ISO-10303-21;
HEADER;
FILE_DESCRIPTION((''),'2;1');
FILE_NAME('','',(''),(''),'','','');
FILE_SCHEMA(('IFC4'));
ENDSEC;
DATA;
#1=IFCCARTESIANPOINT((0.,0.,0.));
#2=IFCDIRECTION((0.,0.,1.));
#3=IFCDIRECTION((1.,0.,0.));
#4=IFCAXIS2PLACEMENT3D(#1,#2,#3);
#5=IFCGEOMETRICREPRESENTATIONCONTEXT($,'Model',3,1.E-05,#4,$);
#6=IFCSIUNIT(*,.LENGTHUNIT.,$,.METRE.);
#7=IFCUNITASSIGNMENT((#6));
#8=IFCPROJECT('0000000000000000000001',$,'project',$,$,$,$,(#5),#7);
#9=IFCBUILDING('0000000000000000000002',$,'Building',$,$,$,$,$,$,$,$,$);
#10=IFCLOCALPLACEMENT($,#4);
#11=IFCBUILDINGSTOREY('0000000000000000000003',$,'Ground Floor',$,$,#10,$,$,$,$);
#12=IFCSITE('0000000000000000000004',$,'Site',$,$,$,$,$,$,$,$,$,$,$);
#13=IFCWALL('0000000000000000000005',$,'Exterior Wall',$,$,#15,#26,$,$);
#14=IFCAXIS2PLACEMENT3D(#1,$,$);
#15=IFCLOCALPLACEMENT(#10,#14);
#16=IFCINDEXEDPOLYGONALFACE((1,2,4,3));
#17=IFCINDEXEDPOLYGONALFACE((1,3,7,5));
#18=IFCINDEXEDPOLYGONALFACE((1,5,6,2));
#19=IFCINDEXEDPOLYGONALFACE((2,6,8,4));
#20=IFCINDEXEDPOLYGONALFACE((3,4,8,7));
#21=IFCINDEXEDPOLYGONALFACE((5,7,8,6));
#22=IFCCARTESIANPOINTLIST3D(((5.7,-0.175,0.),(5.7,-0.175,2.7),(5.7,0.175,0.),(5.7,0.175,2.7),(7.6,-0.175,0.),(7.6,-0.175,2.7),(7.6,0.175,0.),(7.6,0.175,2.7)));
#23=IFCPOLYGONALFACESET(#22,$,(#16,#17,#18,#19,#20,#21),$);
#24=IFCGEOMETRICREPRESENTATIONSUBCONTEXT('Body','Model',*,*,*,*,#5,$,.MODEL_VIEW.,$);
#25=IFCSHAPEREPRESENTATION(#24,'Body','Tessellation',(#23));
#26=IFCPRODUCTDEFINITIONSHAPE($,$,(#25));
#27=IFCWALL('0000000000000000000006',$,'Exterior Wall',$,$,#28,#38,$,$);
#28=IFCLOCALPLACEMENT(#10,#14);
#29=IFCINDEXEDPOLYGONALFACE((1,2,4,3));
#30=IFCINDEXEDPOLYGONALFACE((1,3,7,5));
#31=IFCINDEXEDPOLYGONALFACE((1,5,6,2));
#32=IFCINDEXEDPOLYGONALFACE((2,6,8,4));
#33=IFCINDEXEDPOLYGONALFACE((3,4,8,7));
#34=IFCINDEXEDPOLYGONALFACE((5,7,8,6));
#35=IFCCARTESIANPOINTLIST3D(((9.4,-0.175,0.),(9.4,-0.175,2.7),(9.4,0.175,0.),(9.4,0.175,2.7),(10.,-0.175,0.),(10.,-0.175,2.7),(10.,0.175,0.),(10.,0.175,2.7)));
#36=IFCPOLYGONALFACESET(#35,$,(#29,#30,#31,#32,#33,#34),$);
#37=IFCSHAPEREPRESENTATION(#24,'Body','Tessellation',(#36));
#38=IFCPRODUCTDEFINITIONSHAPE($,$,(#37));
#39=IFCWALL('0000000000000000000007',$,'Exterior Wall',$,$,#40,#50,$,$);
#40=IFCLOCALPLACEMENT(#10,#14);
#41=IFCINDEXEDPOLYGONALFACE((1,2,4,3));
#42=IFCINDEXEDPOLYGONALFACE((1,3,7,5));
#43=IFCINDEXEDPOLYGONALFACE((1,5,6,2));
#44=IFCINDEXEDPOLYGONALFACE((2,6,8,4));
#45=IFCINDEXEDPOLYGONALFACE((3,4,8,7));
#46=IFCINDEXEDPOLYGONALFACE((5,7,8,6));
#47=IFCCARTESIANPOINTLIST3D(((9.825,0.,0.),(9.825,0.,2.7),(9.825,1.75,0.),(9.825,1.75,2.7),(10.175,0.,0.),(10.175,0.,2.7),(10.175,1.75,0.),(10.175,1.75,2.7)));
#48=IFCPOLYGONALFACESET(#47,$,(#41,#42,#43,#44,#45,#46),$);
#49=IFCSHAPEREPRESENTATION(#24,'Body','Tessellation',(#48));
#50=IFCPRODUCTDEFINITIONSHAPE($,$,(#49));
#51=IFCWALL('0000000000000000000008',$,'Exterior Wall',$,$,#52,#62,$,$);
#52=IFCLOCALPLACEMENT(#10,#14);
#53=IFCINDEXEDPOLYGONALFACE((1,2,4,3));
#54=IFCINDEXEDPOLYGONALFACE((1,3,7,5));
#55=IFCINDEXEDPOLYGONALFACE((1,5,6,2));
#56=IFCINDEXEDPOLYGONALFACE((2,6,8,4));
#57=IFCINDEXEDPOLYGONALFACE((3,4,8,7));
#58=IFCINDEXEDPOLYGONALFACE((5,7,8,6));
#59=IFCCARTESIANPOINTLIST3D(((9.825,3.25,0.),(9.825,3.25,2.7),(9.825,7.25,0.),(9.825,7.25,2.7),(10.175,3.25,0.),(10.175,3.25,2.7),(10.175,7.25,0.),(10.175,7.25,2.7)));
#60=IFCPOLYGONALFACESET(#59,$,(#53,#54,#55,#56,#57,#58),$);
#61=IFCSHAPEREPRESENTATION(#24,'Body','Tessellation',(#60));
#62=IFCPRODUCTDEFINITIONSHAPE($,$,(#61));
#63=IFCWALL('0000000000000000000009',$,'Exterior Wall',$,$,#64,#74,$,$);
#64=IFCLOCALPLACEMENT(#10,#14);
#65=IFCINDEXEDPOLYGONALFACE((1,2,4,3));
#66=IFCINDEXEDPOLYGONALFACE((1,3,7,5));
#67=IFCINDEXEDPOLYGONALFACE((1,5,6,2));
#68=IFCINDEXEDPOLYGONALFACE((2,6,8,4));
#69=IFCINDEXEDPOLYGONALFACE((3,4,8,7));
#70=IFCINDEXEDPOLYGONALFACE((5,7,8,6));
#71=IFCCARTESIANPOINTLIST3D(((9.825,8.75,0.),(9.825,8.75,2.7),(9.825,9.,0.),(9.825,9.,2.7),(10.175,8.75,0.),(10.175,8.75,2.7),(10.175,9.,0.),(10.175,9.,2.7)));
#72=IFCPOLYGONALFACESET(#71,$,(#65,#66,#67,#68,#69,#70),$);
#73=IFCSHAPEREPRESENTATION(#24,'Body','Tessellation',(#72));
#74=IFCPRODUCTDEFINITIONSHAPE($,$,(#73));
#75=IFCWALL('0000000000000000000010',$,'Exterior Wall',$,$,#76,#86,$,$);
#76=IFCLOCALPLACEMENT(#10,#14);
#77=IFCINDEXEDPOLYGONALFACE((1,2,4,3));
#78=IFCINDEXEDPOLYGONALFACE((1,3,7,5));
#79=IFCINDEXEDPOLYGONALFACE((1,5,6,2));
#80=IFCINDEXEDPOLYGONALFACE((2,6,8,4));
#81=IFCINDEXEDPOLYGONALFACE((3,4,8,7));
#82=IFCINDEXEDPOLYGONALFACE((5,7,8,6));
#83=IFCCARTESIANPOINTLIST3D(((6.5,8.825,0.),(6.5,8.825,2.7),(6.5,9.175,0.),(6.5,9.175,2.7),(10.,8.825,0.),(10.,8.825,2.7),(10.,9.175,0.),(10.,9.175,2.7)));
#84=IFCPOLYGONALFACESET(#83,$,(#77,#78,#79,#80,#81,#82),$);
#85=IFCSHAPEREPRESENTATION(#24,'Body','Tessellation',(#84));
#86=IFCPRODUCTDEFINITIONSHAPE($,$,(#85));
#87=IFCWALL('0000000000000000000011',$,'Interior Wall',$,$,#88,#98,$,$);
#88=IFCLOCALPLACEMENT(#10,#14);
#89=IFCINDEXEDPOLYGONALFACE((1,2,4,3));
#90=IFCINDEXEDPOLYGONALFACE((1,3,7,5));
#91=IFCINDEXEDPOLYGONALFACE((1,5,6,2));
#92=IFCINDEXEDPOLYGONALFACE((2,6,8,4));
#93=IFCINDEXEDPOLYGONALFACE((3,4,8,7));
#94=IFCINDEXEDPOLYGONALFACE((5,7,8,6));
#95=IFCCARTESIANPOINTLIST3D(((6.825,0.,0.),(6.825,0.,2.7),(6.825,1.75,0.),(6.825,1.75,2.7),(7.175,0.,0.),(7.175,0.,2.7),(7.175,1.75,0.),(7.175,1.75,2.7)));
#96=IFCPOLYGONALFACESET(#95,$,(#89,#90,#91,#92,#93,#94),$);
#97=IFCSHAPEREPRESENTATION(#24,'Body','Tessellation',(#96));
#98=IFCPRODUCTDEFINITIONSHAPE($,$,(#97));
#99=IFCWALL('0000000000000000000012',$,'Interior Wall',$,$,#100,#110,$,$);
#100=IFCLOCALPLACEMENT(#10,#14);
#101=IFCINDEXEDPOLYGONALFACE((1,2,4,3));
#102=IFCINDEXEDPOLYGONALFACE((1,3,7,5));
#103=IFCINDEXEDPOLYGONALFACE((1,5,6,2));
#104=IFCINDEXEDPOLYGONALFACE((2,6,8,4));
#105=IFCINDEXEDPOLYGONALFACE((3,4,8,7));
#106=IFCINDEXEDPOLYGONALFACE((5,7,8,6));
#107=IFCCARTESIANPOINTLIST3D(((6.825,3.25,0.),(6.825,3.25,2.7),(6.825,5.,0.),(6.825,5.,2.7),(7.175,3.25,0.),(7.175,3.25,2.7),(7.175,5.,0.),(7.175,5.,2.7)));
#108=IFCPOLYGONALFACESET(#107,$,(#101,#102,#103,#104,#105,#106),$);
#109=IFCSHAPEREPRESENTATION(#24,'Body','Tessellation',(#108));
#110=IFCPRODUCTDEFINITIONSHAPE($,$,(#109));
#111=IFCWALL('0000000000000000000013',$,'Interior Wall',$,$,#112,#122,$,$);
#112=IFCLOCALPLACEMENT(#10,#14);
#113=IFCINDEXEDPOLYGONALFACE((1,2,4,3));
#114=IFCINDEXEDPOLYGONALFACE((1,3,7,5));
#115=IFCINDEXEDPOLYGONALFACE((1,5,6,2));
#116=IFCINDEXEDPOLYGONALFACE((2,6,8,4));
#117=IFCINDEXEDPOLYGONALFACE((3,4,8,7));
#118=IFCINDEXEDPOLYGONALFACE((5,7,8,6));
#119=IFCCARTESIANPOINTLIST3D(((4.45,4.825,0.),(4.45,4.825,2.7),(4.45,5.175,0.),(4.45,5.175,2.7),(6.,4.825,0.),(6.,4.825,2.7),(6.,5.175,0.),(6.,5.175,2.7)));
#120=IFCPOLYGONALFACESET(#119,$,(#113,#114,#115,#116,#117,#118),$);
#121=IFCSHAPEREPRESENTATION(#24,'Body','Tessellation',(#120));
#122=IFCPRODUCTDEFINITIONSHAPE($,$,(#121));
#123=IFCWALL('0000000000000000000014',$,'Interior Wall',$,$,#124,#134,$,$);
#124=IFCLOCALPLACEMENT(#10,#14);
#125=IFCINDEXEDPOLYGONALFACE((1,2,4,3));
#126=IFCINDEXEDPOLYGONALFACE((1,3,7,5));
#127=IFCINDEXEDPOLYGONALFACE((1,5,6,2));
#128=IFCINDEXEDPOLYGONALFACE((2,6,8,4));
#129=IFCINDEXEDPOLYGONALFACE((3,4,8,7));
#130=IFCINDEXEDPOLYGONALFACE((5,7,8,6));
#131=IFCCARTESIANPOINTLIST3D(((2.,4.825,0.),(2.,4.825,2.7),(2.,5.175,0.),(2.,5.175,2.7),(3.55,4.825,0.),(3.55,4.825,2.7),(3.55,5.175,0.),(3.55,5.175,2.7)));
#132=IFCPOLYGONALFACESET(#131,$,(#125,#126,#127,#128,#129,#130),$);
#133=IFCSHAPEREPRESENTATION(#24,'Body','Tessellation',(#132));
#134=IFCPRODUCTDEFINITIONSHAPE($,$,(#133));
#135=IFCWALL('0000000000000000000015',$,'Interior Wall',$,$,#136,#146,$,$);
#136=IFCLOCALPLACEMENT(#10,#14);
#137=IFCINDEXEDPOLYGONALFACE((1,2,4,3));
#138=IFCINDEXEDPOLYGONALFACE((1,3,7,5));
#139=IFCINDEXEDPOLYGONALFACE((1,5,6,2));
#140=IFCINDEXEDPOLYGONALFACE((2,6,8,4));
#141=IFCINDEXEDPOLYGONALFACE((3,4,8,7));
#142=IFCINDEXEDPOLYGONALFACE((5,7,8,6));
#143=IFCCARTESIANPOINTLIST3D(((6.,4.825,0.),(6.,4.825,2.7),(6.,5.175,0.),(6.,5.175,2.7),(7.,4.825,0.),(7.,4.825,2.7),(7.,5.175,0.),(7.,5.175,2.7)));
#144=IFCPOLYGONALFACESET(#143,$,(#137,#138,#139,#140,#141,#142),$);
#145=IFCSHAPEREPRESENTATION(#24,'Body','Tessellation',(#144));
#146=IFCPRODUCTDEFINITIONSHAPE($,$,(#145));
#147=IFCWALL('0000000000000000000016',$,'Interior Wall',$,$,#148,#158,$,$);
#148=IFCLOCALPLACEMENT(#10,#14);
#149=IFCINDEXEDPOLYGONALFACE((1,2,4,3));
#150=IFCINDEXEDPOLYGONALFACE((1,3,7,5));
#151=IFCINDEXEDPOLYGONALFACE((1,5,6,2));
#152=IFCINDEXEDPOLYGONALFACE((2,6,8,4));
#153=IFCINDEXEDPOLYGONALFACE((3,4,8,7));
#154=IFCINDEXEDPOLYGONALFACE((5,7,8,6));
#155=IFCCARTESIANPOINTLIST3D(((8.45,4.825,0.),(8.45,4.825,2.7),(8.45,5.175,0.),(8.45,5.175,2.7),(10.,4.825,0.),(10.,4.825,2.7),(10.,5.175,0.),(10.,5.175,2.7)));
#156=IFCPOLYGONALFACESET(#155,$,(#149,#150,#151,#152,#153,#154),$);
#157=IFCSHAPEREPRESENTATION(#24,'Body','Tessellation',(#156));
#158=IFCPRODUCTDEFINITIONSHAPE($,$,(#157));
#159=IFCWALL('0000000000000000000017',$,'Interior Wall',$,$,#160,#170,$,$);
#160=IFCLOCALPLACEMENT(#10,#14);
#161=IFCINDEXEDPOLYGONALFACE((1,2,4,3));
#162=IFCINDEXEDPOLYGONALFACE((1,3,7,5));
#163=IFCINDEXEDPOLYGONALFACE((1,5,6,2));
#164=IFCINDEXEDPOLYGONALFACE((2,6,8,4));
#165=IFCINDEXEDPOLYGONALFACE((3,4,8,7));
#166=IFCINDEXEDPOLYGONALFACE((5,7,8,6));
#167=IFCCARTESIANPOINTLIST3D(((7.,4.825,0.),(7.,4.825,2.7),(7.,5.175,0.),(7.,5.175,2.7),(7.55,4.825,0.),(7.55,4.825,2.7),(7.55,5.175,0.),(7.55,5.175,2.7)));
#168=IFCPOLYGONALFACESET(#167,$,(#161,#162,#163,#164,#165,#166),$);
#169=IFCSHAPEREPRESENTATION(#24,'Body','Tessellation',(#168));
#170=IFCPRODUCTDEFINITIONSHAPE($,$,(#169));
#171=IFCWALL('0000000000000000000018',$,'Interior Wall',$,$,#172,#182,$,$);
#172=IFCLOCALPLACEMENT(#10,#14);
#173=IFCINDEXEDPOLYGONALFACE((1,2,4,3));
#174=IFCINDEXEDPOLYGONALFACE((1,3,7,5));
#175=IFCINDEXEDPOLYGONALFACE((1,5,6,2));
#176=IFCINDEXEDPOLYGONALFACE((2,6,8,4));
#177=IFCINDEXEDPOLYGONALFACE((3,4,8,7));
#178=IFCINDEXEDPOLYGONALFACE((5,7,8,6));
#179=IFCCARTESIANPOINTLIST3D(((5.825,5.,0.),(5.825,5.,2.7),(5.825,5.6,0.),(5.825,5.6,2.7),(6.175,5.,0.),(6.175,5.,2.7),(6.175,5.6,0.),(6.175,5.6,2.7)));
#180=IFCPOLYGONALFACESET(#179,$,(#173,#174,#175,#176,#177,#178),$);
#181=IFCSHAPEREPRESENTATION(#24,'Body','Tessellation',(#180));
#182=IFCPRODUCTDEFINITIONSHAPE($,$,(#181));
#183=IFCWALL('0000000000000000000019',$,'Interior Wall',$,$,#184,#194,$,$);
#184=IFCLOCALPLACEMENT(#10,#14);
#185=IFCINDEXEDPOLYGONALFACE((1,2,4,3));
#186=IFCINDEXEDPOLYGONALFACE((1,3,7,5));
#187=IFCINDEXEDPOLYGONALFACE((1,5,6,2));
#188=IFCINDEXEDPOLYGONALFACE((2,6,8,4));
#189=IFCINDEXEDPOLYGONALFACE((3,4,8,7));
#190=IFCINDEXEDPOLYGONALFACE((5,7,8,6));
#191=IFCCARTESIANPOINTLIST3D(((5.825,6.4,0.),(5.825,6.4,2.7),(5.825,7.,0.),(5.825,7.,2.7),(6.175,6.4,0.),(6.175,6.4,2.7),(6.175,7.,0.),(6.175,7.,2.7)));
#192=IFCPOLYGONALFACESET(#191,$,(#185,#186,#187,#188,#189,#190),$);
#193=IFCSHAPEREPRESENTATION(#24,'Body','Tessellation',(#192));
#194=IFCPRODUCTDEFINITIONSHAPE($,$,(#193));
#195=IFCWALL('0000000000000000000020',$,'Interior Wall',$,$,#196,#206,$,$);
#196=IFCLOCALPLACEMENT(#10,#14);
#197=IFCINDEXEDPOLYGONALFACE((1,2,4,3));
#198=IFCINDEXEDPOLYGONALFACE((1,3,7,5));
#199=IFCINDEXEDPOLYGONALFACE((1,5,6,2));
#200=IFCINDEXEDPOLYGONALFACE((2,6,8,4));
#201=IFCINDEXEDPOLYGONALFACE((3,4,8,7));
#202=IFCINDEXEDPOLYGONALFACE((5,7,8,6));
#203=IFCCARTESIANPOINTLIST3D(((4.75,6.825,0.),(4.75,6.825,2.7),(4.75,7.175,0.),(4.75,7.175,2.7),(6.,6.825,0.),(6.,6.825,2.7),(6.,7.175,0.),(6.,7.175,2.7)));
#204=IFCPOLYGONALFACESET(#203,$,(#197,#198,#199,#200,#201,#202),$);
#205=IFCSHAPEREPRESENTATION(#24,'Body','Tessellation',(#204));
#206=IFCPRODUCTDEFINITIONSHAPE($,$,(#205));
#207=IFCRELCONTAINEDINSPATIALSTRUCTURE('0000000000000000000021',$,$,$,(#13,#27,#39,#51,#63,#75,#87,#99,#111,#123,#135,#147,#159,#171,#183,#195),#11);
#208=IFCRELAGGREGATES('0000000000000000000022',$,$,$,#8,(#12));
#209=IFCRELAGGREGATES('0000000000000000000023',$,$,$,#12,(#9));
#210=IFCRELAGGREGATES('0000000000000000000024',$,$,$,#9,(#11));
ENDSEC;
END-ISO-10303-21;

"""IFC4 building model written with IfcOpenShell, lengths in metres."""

from ifc_helpers import new_model, si_unit, frame, origin_with_axes, place, context, subcontext, project, spatial, indexed_curve, outline, extrude, element, save


model = new_model("IFC4")

# Units and contexts
model_context = context("Model", 3, precision=1e-05, world=origin_with_axes())
body_context = subcontext(model_context, "Body", "Model", "MODEL_VIEW")
ifc_project = project(units=[si_unit("LENGTHUNIT", "METRE")], contexts=[model_context])

# Site, building, storey
site = spatial("IfcSite", under=ifc_project, Name="Site")
building = spatial("IfcBuilding", under=site, Name="Building")
storey_placement = place(None, origin_with_axes())
storey = spatial("IfcBuildingStorey", under=building, at=storey_placement, Name="Ground Floor")

# Walls
wall_1_placement = place(storey_placement, frame((5.7, 0.0, 0.0), z_axis=(0.0, 0.0, 1.0), x_axis=(1.0, 0.0, 0.0)))
element("IfcWall", 1, at=wall_1_placement, inside=storey, Name="Exterior Wall", context=body_context, shape_type="SweptSolid", body=[
    extrude(outline(indexed_curve([(0.0, 0.0), (0.0, 0.35), (1.9, 0.35), (1.9, 0.0), (0.0, 0.0)], self_intersect=False)), frame((0.0, -0.175, 0.0), z_axis=(0.0, 0.0, 1.0), x_axis=(1.0, 0.0, 0.0)), (0.0, 0.0, 1.0), 2.7),
])
wall_2_placement = place(storey_placement, frame((9.4, 0.0, 0.0), z_axis=(0.0, 0.0, 1.0), x_axis=(1.0, 0.0, 0.0)))
element("IfcWall", 2, at=wall_2_placement, inside=storey, Name="Exterior Wall", context=body_context, shape_type="SweptSolid", body=[
    extrude(outline(indexed_curve([(0.0, 0.0), (0.0, 0.35), (0.6, 0.35), (0.6, 0.0), (0.0, 0.0)], self_intersect=False)), frame((0.0, -0.175, 0.0), z_axis=(0.0, 0.0, 1.0), x_axis=(1.0, 0.0, 0.0)), (0.0, 0.0, 1.0), 2.7),
])
wall_3_placement = place(storey_placement, frame((10.0, 0.0, 0.0), z_axis=(0.0, 0.0, 1.0), x_axis=(0.0, 1.0, 0.0)))
element("IfcWall", 3, at=wall_3_placement, inside=storey, Name="Exterior Wall", context=body_context, shape_type="SweptSolid", body=[
    extrude(outline(indexed_curve([(0.0, 0.0), (0.0, 0.35), (1.75, 0.35), (1.75, 0.0), (0.0, 0.0)], self_intersect=False)), frame((0.0, -0.175, 0.0), z_axis=(0.0, 0.0, 1.0), x_axis=(1.0, 0.0, 0.0)), (0.0, 0.0, 1.0), 2.7),
])
wall_4_placement = place(storey_placement, frame((10.0, 3.25, 0.0), z_axis=(0.0, 0.0, 1.0), x_axis=(0.0, 1.0, 0.0)))
element("IfcWall", 4, at=wall_4_placement, inside=storey, Name="Exterior Wall", context=body_context, shape_type="SweptSolid", body=[
    extrude(outline(indexed_curve([(0.0, 0.0), (0.0, 0.35), (4.0, 0.35), (4.0, 0.0), (0.0, 0.0)], self_intersect=False)), frame((0.0, -0.175, 0.0), z_axis=(0.0, 0.0, 1.0), x_axis=(1.0, 0.0, 0.0)), (0.0, 0.0, 1.0), 2.7),
])
wall_5_placement = place(storey_placement, frame((10.0, 8.75, 0.0), z_axis=(0.0, 0.0, 1.0), x_axis=(0.0, 1.0, 0.0)))
element("IfcWall", 5, at=wall_5_placement, inside=storey, Name="Exterior Wall", context=body_context, shape_type="SweptSolid", body=[
    extrude(outline(indexed_curve([(0.0, 0.0), (0.0, 0.35), (0.25, 0.35), (0.25, 0.0), (0.0, 0.0)], self_intersect=False)), frame((0.0, -0.175, 0.0), z_axis=(0.0, 0.0, 1.0), x_axis=(1.0, 0.0, 0.0)), (0.0, 0.0, 1.0), 2.7),
])
wall_6_placement = place(storey_placement, frame((10.0, 9.0, 0.0), z_axis=(0.0, 0.0, 1.0), x_axis=(-1.0, 0.0, 0.0)))
element("IfcWall", 6, at=wall_6_placement, inside=storey, Name="Exterior Wall", context=body_context, shape_type="SweptSolid", body=[
    extrude(outline(indexed_curve([(0.0, 0.0), (0.0, 0.35), (3.5, 0.35), (3.5, 0.0), (0.0, 0.0)], self_intersect=False)), frame((0.0, -0.175, 0.0), z_axis=(0.0, 0.0, 1.0), x_axis=(1.0, 0.0, 0.0)), (0.0, 0.0, 1.0), 2.7),
])
for number, where, z_axis, x_axis, name in (
    (7, (7.0, 0.0, 0.0), (0.0, 0.0, 1.0), (0.0, 1.0, 0.0), "Interior Wall"),
    (8, (7.0, 3.25, 0.0), (0.0, 0.0, 1.0), (0.0, 1.0, 0.0), "Interior Wall"),
):
    element("IfcWall", number, at=place(storey_placement, frame(where, z_axis=z_axis, x_axis=x_axis)), inside=storey, Name=name, context=body_context, shape_type="SweptSolid", body=[
        extrude(outline(indexed_curve([(0.0, 0.0), (0.0, 0.35), (1.75, 0.35), (1.75, 0.0), (0.0, 0.0)], self_intersect=False)), frame((0.0, -0.175, 0.0), z_axis=(0.0, 0.0, 1.0), x_axis=(1.0, 0.0, 0.0)), (0.0, 0.0, 1.0), 2.7),
    ])
for number, where, z_axis, x_axis, name in (
    (9, (6.0, 5.0, 0.0), (0.0, 0.0, 1.0), (-1.0, 0.0, 0.0), "Interior Wall"),
    (10, (3.55, 5.0, 0.0), (0.0, 0.0, 1.0), (-1.0, 0.0, 0.0), "Interior Wall"),
):
    element("IfcWall", number, at=place(storey_placement, frame(where, z_axis=z_axis, x_axis=x_axis)), inside=storey, Name=name, context=body_context, shape_type="SweptSolid", body=[
        extrude(outline(indexed_curve([(0.0, 0.0), (0.0, 0.35), (1.55, 0.35), (1.55, 0.0), (0.0, 0.0)], self_intersect=False)), frame((0.0, -0.175, 0.0), z_axis=(0.0, 0.0, 1.0), x_axis=(1.0, 0.0, 0.0)), (0.0, 0.0, 1.0), 2.7),
    ])
wall_7_placement = place(storey_placement, frame((7.0, 5.0, 0.0), z_axis=(0.0, 0.0, 1.0), x_axis=(-1.0, 0.0, 0.0)))
element("IfcWall", 11, at=wall_7_placement, inside=storey, Name="Interior Wall", context=body_context, shape_type="SweptSolid", body=[
    extrude(outline(indexed_curve([(0.0, 0.0), (0.0, 0.35), (1.0, 0.35), (1.0, 0.0), (0.0, 0.0)], self_intersect=False)), frame((0.0, -0.175, 0.0), z_axis=(0.0, 0.0, 1.0), x_axis=(1.0, 0.0, 0.0)), (0.0, 0.0, 1.0), 2.7),
])
wall_8_placement = place(storey_placement, frame((10.0, 5.0, 0.0), z_axis=(0.0, 0.0, 1.0), x_axis=(-1.0, 0.0, 0.0)))
element("IfcWall", 12, at=wall_8_placement, inside=storey, Name="Interior Wall", context=body_context, shape_type="SweptSolid", body=[
    extrude(outline(indexed_curve([(0.0, 0.0), (0.0, 0.35), (1.55, 0.35), (1.55, 0.0), (0.0, 0.0)], self_intersect=False)), frame((0.0, -0.175, 0.0), z_axis=(0.0, 0.0, 1.0), x_axis=(1.0, 0.0, 0.0)), (0.0, 0.0, 1.0), 2.7),
])
wall_9_placement = place(storey_placement, frame((7.55, 5.0, 0.0), z_axis=(0.0, 0.0, 1.0), x_axis=(-1.0, 0.0, 0.0)))
element("IfcWall", 13, at=wall_9_placement, inside=storey, Name="Interior Wall", context=body_context, shape_type="SweptSolid", body=[
    extrude(outline(indexed_curve([(0.0, 0.0), (0.0, 0.35), (0.55, 0.35), (0.55, 0.0), (0.0, 0.0)], self_intersect=False)), frame((0.0, -0.175, 0.0), z_axis=(0.0, 0.0, 1.0), x_axis=(1.0, 0.0, 0.0)), (0.0, 0.0, 1.0), 2.7),
])
for number, where, z_axis, x_axis, name in (
    (14, (6.0, 5.0, 0.0), (0.0, 0.0, 1.0), (0.0, 1.0, 0.0), "Interior Wall"),
    (15, (6.0, 6.4, 0.0), (0.0, 0.0, 1.0), (0.0, 1.0, 0.0), "Interior Wall"),
):
    element("IfcWall", number, at=place(storey_placement, frame(where, z_axis=z_axis, x_axis=x_axis)), inside=storey, Name=name, context=body_context, shape_type="SweptSolid", body=[
        extrude(outline(indexed_curve([(0.0, 0.0), (0.0, 0.35), (0.6, 0.35), (0.6, 0.0), (0.0, 0.0)], self_intersect=False)), frame((0.0, -0.175, 0.0), z_axis=(0.0, 0.0, 1.0), x_axis=(1.0, 0.0, 0.0)), (0.0, 0.0, 1.0), 2.7),
    ])
for number, where, z_axis, x_axis, name in (
    (16, (6.0, 7.0, 0.0), (0.0, 0.0, 1.0), (-1.0, 0.0, 0.0), "Interior Wall"),
):
    element("IfcWall", number, at=place(storey_placement, frame(where, z_axis=z_axis, x_axis=x_axis)), inside=storey, Name=name, context=body_context, shape_type="SweptSolid", body=[
        extrude(outline(indexed_curve([(0.0, 0.0), (0.0, 0.35), (1.25, 0.35), (1.25, 0.0), (0.0, 0.0)], self_intersect=False)), frame((0.0, -0.175, 0.0), z_axis=(0.0, 0.0, 1.0), x_axis=(1.0, 0.0, 0.0)), (0.0, 0.0, 1.0), 2.7),
    ])

save(model, "model.ifc")
